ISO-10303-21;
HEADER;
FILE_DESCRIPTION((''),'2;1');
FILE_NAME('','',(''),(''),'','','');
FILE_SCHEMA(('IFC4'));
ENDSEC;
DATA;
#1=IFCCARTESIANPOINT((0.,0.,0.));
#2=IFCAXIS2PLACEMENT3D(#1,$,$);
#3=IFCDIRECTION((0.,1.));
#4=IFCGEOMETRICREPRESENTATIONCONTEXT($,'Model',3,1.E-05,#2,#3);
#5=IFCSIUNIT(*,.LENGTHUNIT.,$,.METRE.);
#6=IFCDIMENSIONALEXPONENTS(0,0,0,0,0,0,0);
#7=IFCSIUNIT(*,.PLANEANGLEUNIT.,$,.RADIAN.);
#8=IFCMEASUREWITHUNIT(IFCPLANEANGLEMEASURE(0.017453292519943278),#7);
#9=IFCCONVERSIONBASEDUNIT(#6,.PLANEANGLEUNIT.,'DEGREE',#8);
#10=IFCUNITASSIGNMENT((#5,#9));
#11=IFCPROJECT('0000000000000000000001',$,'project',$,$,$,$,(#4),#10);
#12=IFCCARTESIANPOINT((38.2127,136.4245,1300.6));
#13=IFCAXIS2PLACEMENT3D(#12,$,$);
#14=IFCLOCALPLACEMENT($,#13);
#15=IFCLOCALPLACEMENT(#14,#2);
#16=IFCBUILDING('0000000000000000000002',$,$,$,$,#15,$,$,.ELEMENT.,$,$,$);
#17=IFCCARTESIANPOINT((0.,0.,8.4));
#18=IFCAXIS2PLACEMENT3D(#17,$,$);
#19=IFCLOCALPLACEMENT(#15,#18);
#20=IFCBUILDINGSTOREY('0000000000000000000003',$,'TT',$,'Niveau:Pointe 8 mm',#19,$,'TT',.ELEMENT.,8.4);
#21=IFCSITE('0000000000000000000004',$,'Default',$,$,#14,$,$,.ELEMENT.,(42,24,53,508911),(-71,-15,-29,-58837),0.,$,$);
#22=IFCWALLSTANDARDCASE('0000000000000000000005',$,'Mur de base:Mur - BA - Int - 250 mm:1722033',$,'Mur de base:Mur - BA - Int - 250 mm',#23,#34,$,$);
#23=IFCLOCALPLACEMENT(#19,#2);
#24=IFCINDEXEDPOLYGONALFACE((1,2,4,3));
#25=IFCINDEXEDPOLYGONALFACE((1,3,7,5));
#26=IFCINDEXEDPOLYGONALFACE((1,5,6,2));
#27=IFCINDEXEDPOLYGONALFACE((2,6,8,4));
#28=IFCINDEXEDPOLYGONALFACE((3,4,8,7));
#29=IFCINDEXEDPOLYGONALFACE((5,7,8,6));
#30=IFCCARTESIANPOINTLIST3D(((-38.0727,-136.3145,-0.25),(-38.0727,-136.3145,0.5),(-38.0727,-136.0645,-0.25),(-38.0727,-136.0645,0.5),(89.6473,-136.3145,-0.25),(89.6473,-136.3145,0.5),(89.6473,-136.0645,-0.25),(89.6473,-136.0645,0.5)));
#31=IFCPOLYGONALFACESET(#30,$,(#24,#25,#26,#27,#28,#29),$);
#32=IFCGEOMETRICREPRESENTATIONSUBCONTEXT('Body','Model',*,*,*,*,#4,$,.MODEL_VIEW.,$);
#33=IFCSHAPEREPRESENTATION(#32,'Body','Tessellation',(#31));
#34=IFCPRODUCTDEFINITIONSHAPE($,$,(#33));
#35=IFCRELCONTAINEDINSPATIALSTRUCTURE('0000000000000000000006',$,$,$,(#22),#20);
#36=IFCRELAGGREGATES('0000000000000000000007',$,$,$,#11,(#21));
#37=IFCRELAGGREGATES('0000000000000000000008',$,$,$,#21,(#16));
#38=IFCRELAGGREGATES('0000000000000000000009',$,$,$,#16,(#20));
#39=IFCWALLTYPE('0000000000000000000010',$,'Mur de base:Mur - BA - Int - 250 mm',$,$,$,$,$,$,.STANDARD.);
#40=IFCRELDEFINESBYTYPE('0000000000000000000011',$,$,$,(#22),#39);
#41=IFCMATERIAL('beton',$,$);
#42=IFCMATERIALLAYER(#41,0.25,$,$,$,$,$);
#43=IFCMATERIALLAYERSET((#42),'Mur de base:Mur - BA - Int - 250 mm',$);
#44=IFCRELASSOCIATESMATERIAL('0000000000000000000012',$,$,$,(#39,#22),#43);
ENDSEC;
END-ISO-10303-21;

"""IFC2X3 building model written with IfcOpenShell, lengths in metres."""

from ifc_helpers import new_model, entity, si_unit, converted_unit, direction, frame, frame_2d, origin, place, context, subcontext, project, spatial, rectangle, extrude, material, layer, layer_set, layer_usage, type_object, element, save


model = new_model("IFC2X3")

# Units and contexts
model_context = context("Model", 3, precision=1e-05, world=origin(), true_north=direction((0.0, 1.0)))
body_context = subcontext(model_context, "Body", "Model", "MODEL_VIEW")
ifc_project = project(units=[si_unit("LENGTHUNIT", "METRE"), converted_unit("PLANEANGLEUNIT", "DEGREE", entity("IfcPlaneAngleMeasure", 0.017453292519943278), si_unit("PLANEANGLEUNIT", "RADIAN"), dimensions=[0, 0, 0, 0, 0, 0, 0])], contexts=[model_context])

# Site, building, storey
site_placement = place(None, frame((38.2127, 136.4245, 1300.6)))
site = spatial("IfcSite", under=ifc_project, at=site_placement, Name="Default", CompositionType="ELEMENT", RefLatitude=(42, 24, 53, 508911), RefLongitude=(-71, -15, -29, -58837), RefElevation=0.0)
building_placement = place(site_placement, origin())
building = spatial("IfcBuilding", under=site, at=building_placement, CompositionType="ELEMENT")
storey_placement = place(building_placement, frame((0.0, 0.0, 8.4)))
storey = spatial("IfcBuildingStorey", under=building, at=storey_placement, Name="TT", ObjectType="Niveau:Pointe 8 mm", LongName="TT", CompositionType="ELEMENT", Elevation=8.4)

# Wall
ifc_material_1 = material(Name="beton")
ifc_layer_1 = layer(ifc_material_1, 0.25)
ifc_layer_set_1 = layer_set([ifc_layer_1], Name="Mur de base:Mur - BA - Int - 250 mm")
wall_type_1 = type_object("IfcWallType", Name="Mur de base:Mur - BA - Int - 250 mm", PredefinedType="STANDARD", material=ifc_layer_set_1)
ifc_layer_usage_1 = layer_usage(ifc_layer_set_1, "AXIS2", "NEGATIVE", 0.125)
wall_1_placement = place(storey_placement, frame((89.6473, -136.1895, -0.25), z_axis=(0.0, 0.0, 1.0), x_axis=(-1.0, 0.0, 0.0)))
element("IfcWallStandardCase", 1, at=wall_1_placement, inside=storey, type_object=wall_type_1, material=ifc_layer_usage_1, Name="Mur de base:Mur - BA - Int - 250 mm:1722033", ObjectType="Mur de base:Mur - BA - Int - 250 mm", context=body_context, shape_type="SweptSolid", body=[
    extrude(rectangle(XDim=127.72, YDim=0.25, at=frame_2d((63.86, 0.0), x_axis=(-1.0, 0.0))), origin(), (0.0, 0.0, 1.0), 0.75),
])

save(model, "model.ifc")
